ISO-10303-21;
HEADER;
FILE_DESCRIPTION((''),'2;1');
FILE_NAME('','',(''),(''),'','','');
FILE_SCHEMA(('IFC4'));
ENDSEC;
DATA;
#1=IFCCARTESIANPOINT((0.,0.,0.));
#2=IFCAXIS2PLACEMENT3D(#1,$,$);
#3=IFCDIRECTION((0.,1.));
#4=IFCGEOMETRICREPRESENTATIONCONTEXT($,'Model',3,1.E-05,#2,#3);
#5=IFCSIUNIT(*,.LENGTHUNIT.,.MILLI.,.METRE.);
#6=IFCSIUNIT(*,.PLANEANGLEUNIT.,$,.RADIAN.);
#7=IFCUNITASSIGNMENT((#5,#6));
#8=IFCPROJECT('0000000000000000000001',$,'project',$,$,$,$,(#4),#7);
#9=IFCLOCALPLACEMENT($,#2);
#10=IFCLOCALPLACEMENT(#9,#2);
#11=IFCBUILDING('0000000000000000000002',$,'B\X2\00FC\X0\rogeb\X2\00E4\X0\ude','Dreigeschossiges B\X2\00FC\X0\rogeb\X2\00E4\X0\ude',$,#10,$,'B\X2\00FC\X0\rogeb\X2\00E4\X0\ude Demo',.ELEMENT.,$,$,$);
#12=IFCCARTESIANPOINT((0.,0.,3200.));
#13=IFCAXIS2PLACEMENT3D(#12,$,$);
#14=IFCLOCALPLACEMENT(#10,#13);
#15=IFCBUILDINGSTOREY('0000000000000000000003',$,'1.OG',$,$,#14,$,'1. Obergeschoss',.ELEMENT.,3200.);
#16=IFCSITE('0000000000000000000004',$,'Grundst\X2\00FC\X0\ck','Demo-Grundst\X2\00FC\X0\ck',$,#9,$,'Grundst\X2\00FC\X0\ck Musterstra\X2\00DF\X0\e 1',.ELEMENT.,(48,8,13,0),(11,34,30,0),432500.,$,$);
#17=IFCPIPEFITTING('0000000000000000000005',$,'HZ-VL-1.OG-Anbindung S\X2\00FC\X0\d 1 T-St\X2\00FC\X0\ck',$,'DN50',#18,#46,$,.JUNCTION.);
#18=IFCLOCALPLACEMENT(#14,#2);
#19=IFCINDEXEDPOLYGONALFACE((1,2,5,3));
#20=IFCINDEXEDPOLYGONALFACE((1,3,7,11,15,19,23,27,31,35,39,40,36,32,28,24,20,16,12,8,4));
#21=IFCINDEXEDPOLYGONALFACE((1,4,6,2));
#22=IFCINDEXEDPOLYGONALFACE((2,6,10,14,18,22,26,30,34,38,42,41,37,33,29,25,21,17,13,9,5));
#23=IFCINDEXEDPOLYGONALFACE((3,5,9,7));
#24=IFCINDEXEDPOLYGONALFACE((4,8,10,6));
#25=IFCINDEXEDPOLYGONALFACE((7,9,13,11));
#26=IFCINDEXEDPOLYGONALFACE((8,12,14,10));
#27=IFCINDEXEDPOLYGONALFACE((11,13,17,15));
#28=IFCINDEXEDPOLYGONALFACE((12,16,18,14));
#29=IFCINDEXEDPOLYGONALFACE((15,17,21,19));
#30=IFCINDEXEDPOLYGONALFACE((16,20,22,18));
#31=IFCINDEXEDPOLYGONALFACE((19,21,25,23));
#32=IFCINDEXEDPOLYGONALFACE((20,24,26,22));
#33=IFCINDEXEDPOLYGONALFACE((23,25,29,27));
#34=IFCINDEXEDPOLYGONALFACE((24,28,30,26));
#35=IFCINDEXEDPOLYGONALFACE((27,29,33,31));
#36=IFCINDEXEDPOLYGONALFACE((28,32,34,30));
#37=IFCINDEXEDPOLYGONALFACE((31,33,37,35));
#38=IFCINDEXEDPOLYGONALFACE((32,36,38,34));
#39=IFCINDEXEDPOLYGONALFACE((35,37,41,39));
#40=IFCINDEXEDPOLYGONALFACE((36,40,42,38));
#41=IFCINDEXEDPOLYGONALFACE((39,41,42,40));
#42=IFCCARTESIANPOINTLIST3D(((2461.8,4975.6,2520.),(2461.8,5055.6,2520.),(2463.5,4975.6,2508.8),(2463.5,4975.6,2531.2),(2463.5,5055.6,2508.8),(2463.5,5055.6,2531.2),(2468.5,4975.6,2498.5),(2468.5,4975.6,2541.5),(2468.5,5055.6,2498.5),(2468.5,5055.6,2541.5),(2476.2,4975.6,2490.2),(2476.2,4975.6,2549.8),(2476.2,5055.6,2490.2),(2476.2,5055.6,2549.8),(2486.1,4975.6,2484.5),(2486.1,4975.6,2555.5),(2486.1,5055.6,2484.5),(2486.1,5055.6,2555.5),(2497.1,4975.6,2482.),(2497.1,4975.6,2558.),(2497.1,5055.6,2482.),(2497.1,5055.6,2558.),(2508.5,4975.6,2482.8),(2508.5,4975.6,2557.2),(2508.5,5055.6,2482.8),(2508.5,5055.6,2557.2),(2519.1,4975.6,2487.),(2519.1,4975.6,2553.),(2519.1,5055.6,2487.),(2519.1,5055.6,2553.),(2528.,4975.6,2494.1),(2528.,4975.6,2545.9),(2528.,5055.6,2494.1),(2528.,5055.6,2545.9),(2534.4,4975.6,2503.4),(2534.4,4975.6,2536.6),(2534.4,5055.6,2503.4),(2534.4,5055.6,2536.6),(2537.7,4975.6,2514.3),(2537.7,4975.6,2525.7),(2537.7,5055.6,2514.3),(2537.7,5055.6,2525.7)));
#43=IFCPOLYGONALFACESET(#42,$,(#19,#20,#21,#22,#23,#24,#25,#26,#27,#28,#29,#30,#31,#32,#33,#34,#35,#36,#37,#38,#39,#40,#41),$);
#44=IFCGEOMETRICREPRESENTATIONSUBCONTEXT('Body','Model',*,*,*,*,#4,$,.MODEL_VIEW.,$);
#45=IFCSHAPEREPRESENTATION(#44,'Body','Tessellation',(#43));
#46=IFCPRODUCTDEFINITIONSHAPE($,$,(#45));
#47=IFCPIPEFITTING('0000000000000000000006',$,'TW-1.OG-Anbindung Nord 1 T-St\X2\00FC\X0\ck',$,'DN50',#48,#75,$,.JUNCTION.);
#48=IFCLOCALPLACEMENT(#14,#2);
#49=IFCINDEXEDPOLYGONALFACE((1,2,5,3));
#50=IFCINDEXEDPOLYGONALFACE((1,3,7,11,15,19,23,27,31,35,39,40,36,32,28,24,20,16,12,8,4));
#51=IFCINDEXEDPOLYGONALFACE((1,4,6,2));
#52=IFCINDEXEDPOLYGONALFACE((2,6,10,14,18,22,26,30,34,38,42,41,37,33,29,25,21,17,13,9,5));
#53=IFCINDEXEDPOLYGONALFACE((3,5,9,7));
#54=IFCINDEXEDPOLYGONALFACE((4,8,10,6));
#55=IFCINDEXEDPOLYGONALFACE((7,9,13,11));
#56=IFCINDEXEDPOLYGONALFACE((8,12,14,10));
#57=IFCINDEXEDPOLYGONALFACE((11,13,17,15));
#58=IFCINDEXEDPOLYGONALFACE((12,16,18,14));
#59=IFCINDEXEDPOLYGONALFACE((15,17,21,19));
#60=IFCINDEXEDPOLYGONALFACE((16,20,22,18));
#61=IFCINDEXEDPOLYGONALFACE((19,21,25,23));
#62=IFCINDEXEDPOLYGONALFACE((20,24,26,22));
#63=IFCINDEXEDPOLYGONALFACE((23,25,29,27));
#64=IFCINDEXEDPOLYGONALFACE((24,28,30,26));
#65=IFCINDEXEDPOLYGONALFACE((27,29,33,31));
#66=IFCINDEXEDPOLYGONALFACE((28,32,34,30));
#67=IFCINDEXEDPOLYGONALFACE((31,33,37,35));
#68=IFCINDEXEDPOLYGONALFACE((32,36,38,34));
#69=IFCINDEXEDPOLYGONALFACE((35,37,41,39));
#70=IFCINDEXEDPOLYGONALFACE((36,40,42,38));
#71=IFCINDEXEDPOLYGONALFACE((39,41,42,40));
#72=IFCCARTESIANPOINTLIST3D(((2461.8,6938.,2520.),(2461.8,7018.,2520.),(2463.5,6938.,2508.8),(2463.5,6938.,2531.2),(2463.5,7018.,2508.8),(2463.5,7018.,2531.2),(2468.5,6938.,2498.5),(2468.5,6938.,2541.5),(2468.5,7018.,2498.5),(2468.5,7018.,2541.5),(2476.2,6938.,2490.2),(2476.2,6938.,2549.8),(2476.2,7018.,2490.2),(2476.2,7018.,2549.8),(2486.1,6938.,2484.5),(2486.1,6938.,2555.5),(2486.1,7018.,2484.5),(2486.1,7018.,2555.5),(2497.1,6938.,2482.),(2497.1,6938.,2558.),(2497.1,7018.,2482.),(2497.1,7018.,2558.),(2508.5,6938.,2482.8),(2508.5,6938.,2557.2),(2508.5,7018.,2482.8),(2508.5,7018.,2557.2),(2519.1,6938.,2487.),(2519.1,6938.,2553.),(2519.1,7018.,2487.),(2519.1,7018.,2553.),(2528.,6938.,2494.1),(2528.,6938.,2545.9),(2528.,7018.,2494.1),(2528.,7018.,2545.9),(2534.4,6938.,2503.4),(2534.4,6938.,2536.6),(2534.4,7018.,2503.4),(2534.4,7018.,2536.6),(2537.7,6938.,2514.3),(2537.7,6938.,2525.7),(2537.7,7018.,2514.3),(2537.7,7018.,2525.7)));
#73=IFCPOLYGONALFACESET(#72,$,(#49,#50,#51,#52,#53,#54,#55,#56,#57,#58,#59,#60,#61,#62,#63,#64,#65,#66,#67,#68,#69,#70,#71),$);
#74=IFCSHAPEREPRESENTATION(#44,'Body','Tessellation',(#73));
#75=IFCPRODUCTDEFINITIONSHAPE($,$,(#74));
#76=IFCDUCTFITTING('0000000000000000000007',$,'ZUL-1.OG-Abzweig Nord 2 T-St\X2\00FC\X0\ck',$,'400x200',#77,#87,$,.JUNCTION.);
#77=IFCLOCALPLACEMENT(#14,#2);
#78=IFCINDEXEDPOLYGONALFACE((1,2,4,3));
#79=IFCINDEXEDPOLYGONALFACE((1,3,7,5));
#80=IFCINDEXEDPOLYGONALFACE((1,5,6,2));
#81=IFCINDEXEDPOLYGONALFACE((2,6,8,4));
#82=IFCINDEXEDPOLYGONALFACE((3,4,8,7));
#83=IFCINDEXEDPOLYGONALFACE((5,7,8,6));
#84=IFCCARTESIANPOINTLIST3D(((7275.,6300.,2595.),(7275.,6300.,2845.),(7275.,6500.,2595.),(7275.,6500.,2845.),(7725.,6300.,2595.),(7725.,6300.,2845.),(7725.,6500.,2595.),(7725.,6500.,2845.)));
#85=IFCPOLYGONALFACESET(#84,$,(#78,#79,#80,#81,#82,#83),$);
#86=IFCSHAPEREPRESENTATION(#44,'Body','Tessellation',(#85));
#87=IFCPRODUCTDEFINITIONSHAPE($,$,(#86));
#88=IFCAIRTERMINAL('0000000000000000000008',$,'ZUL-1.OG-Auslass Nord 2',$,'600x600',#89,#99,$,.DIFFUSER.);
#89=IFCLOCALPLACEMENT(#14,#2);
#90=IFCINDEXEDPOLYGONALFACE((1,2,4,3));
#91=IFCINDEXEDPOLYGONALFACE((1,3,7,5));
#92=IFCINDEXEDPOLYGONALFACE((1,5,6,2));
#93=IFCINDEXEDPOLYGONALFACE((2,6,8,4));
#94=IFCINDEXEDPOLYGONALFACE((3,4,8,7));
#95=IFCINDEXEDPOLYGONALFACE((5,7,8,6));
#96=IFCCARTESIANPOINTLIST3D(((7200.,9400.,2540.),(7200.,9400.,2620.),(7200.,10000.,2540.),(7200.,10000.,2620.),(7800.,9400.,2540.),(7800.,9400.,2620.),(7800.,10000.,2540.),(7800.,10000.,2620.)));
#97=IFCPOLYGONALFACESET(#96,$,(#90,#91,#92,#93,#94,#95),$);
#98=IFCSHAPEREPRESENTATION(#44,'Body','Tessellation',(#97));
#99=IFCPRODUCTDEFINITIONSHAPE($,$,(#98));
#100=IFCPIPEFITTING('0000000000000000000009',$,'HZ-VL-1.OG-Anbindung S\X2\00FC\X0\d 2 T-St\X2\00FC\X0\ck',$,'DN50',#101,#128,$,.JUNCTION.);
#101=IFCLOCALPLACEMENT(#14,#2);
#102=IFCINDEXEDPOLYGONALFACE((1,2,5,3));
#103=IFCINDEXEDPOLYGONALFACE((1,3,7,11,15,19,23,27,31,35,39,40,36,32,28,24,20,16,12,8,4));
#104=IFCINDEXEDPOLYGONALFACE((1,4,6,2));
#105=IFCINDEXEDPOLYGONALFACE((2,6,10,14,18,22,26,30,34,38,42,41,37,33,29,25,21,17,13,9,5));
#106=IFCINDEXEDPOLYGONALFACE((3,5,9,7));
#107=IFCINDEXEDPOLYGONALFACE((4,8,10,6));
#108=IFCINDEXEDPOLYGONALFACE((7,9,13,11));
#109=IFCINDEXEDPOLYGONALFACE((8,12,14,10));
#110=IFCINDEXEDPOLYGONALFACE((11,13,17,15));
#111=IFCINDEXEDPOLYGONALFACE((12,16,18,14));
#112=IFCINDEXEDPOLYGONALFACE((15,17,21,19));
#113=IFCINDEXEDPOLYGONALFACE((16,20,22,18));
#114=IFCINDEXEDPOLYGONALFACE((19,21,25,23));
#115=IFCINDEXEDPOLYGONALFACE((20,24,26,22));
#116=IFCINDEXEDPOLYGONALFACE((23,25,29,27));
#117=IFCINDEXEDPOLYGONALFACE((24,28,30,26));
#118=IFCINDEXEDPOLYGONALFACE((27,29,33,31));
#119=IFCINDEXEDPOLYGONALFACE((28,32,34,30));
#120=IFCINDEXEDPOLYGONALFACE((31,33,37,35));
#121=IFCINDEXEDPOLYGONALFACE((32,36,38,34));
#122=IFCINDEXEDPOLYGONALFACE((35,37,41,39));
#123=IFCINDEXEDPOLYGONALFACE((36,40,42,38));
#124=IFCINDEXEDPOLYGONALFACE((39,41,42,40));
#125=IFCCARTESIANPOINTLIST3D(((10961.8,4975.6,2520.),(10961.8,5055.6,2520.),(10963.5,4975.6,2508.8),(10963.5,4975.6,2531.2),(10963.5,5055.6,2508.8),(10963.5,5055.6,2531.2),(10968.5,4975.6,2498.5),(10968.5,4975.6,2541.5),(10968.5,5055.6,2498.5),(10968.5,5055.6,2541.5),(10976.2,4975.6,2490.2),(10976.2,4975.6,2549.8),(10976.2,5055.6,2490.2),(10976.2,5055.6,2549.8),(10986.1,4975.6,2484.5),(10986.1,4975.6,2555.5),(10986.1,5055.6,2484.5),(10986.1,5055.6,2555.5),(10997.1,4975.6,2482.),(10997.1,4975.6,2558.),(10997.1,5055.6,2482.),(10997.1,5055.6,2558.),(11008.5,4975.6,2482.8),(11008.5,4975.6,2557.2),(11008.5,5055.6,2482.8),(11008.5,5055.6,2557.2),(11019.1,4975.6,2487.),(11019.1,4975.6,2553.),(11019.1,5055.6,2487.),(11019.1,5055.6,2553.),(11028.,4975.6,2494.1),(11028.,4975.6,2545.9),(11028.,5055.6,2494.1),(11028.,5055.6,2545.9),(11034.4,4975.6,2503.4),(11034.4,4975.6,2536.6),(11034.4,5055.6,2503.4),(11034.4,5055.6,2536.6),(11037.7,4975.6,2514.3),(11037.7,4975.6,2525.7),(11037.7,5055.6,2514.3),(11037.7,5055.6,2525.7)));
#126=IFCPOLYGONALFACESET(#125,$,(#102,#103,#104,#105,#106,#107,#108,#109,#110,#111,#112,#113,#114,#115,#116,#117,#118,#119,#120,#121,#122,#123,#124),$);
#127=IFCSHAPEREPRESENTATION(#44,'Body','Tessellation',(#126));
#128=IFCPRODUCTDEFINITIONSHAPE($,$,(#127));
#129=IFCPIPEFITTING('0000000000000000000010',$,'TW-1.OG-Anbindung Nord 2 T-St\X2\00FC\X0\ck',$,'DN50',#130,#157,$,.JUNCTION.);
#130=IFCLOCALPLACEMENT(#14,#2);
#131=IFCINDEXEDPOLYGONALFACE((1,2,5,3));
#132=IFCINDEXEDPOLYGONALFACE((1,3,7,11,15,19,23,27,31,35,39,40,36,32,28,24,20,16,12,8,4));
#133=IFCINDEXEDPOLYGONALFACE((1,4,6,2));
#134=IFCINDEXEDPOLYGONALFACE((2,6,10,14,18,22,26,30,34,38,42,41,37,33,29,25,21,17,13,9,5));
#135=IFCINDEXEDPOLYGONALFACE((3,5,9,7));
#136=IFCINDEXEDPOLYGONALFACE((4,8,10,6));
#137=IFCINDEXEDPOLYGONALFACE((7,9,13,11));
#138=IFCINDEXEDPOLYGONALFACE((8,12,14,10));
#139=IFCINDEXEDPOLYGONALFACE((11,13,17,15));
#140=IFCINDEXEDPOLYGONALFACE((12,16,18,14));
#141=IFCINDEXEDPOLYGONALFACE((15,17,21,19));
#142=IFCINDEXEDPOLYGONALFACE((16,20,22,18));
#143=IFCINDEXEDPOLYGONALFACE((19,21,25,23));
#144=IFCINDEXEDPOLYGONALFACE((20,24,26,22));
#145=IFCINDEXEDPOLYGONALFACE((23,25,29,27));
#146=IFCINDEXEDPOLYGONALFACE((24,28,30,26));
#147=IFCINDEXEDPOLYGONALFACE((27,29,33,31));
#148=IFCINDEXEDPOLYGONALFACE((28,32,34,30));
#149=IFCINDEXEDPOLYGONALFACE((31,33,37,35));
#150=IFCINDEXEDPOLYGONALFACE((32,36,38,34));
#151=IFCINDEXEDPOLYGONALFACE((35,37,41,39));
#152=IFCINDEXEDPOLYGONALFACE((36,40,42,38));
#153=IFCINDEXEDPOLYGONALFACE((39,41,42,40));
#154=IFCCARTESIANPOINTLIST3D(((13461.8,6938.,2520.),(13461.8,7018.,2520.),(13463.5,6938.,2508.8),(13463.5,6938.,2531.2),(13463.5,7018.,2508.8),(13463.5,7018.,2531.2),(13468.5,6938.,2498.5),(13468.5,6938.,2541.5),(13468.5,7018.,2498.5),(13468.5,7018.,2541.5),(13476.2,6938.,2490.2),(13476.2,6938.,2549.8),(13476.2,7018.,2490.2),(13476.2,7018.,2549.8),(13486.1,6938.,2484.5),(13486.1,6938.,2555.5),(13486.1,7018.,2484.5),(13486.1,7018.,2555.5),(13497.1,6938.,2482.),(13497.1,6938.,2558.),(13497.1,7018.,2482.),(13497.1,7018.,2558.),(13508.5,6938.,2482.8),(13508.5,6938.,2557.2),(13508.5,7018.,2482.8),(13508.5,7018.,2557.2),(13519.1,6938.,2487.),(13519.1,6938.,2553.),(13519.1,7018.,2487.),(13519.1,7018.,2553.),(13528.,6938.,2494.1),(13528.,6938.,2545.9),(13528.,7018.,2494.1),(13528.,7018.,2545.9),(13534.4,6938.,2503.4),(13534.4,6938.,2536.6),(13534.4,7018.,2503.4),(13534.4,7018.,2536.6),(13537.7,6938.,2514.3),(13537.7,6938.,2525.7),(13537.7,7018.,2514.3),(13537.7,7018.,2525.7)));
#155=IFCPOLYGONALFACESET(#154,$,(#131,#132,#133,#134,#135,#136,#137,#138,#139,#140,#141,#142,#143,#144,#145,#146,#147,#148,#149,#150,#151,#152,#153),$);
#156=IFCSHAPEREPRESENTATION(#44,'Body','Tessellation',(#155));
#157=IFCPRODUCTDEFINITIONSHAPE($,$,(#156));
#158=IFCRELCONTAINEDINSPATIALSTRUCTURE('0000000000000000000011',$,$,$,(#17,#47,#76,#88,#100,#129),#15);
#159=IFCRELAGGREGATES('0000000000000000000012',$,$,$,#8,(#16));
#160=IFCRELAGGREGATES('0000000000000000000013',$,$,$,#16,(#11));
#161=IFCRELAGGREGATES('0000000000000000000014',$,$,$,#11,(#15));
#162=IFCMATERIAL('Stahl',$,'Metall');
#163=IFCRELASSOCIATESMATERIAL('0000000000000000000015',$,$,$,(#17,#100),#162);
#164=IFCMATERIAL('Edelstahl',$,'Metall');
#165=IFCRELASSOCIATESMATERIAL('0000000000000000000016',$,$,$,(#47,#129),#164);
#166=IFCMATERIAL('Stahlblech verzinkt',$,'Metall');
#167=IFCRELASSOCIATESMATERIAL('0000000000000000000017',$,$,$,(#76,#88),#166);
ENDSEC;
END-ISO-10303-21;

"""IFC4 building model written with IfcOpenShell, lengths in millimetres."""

from ifc_helpers import new_model, si_unit, direction, frame, origin, origin_2d, place, context, subcontext, project, spatial, rectangle, circle, extrude, material, element, save


model = new_model("IFC4")

# Units and contexts
model_context = context("Model", 3, precision=1e-05, world=origin(), true_north=direction((0.0, 1.0)))
body_context = subcontext(model_context, "Body", "Model", "MODEL_VIEW")
ifc_project = project(units=[si_unit("LENGTHUNIT", "METRE", prefix="MILLI"), si_unit("PLANEANGLEUNIT", "RADIAN")], contexts=[model_context])

# Site, building, storey
site_placement = place(None, origin())
site = spatial("IfcSite", under=ifc_project, at=site_placement, Name="Grundstück", Description="Demo-Grundstück", LongName="Grundstück Musterstraße 1", CompositionType="ELEMENT", RefLatitude=(48, 8, 13, 0), RefLongitude=(11, 34, 30, 0), RefElevation=432500.0)
building_placement = place(site_placement, origin())
building = spatial("IfcBuilding", under=site, at=building_placement, Name="Bürogebäude", Description="Dreigeschossiges Bürogebäude", LongName="Bürogebäude Demo", CompositionType="ELEMENT")
storey_placement = place(building_placement, frame((0.0, 0.0, 3200.0)))
storey = spatial("IfcBuildingStorey", under=building, at=storey_placement, Name="1.OG", LongName="1. Obergeschoss", CompositionType="ELEMENT", Elevation=3200.0)

# Shared definitions
ifc_material_1 = material(Name="Stahlblech verzinkt", Category="Metall")

# Shared definitions
ifc_material_2 = material(Name="Stahl", Category="Metall")
ifc_material_3 = material(Name="Edelstahl", Category="Metall")

# Pipe fittings
pipe_fitting_1_placement = place(storey_placement, frame((2500.0, 4975.6, 2520.0)))
element("IfcPipeFitting", 1, at=pipe_fitting_1_placement, inside=storey, material=ifc_material_2, Name="HZ-VL-1.OG-Anbindung Süd 1 T-Stück", ObjectType="DN50", PredefinedType="JUNCTION", context=body_context, shape_type="SweptSolid", body=[
    extrude(circle(Radius=38.1, at=origin_2d()), frame((0.0, 0.0, 0.0), z_axis=(0.0, 1.0, 0.0), x_axis=(-1.0, 0.0, 0.0)), (0.0, 0.0, 1.0), 80.0),
])
pipe_fitting_2_placement = place(storey_placement, frame((2500.0, 6938.1, 2520.0)))
element("IfcPipeFitting", 2, at=pipe_fitting_2_placement, inside=storey, material=ifc_material_3, Name="TW-1.OG-Anbindung Nord 1 T-Stück", ObjectType="DN50", PredefinedType="JUNCTION", context=body_context, shape_type="SweptSolid", body=[
    extrude(circle(Radius=38.1, at=origin_2d()), frame((0.0, 0.0, 0.0), z_axis=(0.0, 1.0, 0.0), x_axis=(-1.0, 0.0, 0.0)), (0.0, 0.0, 1.0), 80.0),
])

# Duct fitting
duct_fitting_1_placement = place(storey_placement, frame((7500.0, 6300.0, 2720.0)))
element("IfcDuctFitting", 3, at=duct_fitting_1_placement, inside=storey, material=ifc_material_1, Name="ZUL-1.OG-Abzweig Nord 2 T-Stück", ObjectType="400x200", PredefinedType="JUNCTION", context=body_context, shape_type="SweptSolid", body=[
    extrude(rectangle(XDim=450.0, YDim=250.0, at=origin_2d()), frame((0.0, 0.0, 0.0), z_axis=(0.0, 1.0, 0.0), x_axis=(-1.0, 0.0, 0.0)), (0.0, 0.0, 1.0), 200.0),
])

# Air terminal
air_terminal_1_placement = place(storey_placement, frame((7500.0, 9700.0, 2540.0)))
element("IfcAirTerminal", 4, at=air_terminal_1_placement, inside=storey, material=ifc_material_1, Name="ZUL-1.OG-Auslass Nord 2", ObjectType="600x600", PredefinedType="DIFFUSER", context=body_context, shape_type="SweptSolid", body=[
    extrude(rectangle(XDim=600.0, YDim=600.0, at=origin_2d()), origin(), (0.0, 0.0, 1.0), 80.0),
])

# Pipe fittings
pipe_fitting_3_placement = place(storey_placement, frame((11000.0, 4975.6, 2520.0)))
element("IfcPipeFitting", 5, at=pipe_fitting_3_placement, inside=storey, material=ifc_material_2, Name="HZ-VL-1.OG-Anbindung Süd 2 T-Stück", ObjectType="DN50", PredefinedType="JUNCTION", context=body_context, shape_type="SweptSolid", body=[
    extrude(circle(Radius=38.1, at=origin_2d()), frame((0.0, 0.0, 0.0), z_axis=(0.0, 1.0, 0.0), x_axis=(-1.0, 0.0, 0.0)), (0.0, 0.0, 1.0), 80.0),
])
pipe_fitting_4_placement = place(storey_placement, frame((13500.0, 6938.1, 2520.0)))
element("IfcPipeFitting", 6, at=pipe_fitting_4_placement, inside=storey, material=ifc_material_3, Name="TW-1.OG-Anbindung Nord 2 T-Stück", ObjectType="DN50", PredefinedType="JUNCTION", context=body_context, shape_type="SweptSolid", body=[
    extrude(circle(Radius=38.1, at=origin_2d()), frame((0.0, 0.0, 0.0), z_axis=(0.0, 1.0, 0.0), x_axis=(-1.0, 0.0, 0.0)), (0.0, 0.0, 1.0), 80.0),
])

save(model, "model.ifc")
